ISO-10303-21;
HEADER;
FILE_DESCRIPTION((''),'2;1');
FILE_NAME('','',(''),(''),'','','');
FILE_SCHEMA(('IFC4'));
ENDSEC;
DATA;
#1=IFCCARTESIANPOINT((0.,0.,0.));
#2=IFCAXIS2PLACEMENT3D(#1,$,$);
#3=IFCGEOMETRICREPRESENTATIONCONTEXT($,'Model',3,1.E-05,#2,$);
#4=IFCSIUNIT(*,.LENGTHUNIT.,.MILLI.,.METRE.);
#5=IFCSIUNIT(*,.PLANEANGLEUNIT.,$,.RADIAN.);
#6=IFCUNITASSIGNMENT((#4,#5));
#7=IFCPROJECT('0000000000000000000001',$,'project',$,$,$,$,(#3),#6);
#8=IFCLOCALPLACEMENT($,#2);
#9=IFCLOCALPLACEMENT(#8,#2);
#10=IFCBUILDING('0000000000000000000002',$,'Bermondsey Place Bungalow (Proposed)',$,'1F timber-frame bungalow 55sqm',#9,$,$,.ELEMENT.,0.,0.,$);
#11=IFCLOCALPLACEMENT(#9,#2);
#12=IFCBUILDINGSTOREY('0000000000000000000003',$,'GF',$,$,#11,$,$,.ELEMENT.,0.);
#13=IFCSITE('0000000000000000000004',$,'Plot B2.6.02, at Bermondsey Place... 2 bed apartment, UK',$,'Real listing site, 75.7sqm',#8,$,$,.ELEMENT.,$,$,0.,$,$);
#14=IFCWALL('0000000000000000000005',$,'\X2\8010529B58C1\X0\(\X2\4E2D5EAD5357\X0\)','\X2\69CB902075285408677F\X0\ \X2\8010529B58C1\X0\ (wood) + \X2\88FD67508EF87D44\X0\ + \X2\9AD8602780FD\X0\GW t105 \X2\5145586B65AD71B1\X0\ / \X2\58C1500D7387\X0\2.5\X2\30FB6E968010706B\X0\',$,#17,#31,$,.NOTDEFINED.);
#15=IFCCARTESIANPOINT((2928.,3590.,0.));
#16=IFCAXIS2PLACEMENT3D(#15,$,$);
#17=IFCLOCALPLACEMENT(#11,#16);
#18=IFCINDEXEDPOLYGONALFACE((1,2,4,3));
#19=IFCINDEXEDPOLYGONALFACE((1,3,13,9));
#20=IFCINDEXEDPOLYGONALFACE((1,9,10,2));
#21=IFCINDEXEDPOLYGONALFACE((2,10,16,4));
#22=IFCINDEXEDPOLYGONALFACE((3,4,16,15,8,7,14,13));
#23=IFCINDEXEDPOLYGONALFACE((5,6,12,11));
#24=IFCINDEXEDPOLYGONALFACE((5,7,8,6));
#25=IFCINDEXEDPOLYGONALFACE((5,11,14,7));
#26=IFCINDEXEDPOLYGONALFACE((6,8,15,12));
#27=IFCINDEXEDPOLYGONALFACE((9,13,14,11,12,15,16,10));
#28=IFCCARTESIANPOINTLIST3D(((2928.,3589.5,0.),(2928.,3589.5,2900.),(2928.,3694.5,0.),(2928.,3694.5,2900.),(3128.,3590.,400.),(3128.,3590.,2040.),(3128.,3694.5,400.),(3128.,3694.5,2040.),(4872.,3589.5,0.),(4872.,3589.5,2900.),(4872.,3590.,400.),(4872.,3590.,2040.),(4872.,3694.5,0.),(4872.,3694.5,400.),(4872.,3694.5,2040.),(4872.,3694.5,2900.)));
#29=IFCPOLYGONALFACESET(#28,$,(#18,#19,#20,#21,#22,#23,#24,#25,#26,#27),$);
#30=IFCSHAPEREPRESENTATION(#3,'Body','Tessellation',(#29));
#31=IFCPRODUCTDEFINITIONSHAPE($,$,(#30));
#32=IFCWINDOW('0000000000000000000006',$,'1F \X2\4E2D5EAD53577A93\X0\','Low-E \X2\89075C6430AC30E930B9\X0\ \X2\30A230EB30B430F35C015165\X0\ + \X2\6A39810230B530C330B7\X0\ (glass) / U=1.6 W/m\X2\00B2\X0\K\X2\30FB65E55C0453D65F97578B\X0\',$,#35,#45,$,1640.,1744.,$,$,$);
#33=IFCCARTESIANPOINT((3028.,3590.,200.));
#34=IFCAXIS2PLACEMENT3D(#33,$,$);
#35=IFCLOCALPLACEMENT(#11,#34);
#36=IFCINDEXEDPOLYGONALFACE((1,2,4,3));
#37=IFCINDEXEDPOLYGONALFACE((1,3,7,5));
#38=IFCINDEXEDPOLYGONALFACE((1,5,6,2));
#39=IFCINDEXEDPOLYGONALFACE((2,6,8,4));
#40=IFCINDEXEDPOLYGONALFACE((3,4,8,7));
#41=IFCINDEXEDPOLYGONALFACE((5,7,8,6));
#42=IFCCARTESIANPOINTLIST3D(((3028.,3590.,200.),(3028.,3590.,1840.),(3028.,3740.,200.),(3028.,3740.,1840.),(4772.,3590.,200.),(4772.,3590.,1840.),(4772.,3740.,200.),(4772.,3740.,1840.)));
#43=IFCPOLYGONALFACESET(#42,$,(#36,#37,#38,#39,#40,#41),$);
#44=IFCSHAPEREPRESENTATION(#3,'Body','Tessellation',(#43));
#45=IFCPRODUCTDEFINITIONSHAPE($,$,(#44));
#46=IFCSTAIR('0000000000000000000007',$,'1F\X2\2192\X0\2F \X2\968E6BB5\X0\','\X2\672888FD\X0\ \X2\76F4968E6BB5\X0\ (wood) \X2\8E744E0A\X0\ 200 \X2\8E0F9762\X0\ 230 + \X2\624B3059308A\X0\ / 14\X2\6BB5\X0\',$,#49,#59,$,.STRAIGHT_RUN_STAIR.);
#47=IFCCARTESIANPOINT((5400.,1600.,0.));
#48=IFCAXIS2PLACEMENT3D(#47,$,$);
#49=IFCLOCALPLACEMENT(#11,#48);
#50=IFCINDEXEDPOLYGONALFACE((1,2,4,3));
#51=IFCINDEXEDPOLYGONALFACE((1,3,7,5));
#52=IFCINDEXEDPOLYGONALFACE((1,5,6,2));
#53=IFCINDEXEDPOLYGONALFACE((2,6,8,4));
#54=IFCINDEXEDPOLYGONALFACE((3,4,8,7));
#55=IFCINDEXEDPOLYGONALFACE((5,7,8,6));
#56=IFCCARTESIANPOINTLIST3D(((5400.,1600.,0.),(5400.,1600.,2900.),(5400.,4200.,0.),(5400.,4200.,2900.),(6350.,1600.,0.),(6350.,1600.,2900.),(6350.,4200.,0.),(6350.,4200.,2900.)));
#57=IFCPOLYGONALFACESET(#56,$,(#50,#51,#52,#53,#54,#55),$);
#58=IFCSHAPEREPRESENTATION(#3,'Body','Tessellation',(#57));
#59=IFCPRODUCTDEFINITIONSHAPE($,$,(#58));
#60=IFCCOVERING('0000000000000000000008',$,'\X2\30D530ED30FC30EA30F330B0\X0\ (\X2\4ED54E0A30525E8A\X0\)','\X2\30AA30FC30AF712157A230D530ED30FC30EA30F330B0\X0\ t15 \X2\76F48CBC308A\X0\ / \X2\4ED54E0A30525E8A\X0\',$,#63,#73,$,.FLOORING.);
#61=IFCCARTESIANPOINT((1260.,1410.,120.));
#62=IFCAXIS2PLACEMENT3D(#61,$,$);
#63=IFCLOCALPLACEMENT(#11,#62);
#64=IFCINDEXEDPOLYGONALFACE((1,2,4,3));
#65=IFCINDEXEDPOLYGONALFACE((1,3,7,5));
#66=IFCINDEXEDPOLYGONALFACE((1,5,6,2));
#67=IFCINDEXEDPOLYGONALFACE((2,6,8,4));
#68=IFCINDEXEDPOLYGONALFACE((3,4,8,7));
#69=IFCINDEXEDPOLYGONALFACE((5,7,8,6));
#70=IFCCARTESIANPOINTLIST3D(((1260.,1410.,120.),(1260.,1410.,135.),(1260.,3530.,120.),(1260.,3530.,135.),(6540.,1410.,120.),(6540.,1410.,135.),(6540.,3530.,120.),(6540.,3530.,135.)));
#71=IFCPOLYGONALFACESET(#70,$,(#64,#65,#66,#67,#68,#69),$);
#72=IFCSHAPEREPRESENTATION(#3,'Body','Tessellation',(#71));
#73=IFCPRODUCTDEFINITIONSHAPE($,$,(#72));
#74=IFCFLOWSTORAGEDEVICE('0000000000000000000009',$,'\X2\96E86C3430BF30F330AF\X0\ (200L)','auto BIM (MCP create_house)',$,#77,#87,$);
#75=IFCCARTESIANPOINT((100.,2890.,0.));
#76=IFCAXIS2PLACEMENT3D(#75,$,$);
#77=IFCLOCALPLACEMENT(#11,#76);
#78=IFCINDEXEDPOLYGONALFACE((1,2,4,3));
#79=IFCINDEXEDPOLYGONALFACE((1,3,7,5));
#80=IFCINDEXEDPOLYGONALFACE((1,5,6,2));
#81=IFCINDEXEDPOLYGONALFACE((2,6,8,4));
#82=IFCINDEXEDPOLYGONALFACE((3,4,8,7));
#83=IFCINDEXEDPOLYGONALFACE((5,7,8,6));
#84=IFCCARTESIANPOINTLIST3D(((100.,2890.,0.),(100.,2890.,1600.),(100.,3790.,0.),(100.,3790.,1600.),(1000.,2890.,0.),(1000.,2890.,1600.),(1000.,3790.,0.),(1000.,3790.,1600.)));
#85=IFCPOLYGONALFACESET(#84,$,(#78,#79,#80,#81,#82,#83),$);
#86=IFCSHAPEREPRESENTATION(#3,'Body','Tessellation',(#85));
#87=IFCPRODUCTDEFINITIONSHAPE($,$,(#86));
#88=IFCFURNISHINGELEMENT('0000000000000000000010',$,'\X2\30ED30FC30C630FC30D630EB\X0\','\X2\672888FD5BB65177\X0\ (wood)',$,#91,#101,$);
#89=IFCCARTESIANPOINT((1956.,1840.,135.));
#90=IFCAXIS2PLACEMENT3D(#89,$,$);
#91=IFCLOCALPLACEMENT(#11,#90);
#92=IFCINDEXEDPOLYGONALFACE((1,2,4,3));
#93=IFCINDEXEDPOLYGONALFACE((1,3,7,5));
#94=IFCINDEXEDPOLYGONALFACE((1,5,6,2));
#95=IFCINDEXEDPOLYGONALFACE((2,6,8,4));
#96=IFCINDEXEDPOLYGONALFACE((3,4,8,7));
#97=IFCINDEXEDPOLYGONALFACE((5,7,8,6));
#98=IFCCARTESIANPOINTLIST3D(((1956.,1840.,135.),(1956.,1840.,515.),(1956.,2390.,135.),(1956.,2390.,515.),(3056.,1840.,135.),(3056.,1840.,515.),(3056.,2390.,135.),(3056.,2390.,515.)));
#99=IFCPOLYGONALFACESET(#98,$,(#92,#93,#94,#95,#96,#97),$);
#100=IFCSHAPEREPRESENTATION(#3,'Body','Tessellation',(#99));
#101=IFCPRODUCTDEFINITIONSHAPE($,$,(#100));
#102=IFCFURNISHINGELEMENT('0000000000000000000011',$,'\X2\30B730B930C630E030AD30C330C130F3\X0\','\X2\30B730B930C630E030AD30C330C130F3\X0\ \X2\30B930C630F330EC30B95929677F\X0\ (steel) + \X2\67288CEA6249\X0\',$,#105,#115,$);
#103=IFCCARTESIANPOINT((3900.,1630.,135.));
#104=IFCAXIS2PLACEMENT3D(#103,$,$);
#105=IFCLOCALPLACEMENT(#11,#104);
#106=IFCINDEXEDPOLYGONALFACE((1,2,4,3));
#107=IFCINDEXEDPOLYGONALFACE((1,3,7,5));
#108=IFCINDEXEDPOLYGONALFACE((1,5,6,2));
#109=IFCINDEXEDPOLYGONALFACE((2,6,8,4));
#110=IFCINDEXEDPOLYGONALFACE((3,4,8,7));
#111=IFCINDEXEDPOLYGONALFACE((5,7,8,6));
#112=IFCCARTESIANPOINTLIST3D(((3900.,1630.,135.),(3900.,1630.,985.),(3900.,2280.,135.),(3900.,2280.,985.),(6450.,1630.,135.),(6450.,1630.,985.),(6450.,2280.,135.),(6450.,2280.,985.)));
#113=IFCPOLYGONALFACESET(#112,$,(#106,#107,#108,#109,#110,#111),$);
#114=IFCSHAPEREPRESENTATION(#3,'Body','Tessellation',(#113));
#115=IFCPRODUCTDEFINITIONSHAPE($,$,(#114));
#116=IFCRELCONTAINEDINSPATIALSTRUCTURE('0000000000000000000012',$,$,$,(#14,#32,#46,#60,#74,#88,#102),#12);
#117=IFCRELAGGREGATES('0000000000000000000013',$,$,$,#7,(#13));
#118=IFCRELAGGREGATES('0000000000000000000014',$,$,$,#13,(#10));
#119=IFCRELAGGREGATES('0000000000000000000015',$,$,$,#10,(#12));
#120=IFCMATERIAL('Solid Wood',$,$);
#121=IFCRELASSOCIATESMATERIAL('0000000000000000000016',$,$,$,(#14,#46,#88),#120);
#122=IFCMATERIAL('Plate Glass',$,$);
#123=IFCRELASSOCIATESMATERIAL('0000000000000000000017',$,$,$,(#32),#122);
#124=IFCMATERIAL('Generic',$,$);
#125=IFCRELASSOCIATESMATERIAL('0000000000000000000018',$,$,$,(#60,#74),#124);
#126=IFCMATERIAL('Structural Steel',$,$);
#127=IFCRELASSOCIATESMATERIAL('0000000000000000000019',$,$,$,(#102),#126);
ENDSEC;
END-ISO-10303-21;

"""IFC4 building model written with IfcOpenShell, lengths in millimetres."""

from ifc_helpers import new_model, si_unit, frame, frame_2d, origin, place, context, project, spatial, rectangle, extrude, material, element, fill, save


model = new_model("IFC4")

# Units and contexts
model_context = context("Model", 3, precision=1e-05, world=origin())
ifc_project = project(units=[si_unit("LENGTHUNIT", "METRE", prefix="MILLI"), si_unit("PLANEANGLEUNIT", "RADIAN")], contexts=[model_context])

# Site, building, storey
site_placement = place(None, origin())
site = spatial("IfcSite", under=ifc_project, at=site_placement, Name="Plot B2.6.02, at Bermondsey Place... 2 bed apartment, UK", ObjectType="Real listing site, 75.7sqm", CompositionType="ELEMENT", RefElevation=0.0)
building_placement = place(site_placement, origin())
building = spatial("IfcBuilding", under=site, at=building_placement, Name="Bermondsey Place Bungalow (Proposed)", ObjectType="1F timber-frame bungalow 55sqm", CompositionType="ELEMENT", ElevationOfRefHeight=0.0, ElevationOfTerrain=0.0)
storey_placement = place(building_placement, origin())
storey = spatial("IfcBuildingStorey", under=building, at=storey_placement, Name="GF", CompositionType="ELEMENT", Elevation=0.0)

# Shared definitions
ifc_material_1 = material(Name="Solid Wood")

# Shared definitions
ifc_material_2 = material(Name="Plate Glass")

# Wall, opening, window
wall_1_placement = place(storey_placement, frame((2928.0, 3590.0, 0.0)))
wall_1 = element("IfcWall", 1, at=wall_1_placement, inside=storey, material=ifc_material_1, Name="耐力壁(中庭南)", Description="構造用合板 耐力壁 (wood) + 製材軸組 + 高性能GW t105 充填断熱 / 壁倍率2.5・準耐火", PredefinedType="NOTDEFINED", context=model_context, shape_type="SweptSolid", body=[
    extrude(rectangle(XDim=1944.0, YDim=105.0, at=frame_2d((972.0, 52.0))), frame((2928.0, 3590.0, 0.0)), (0.0, 0.0, 1.0), 2900.0),
])
opening_1_placement = place(storey_placement, frame((3028.0, 3590.0, 200.0)))
opening_1 = element("IfcOpeningElement", 2, at=opening_1_placement, cuts=wall_1, PredefinedType="NOTDEFINED", context=model_context, shape_type="SweptSolid", body=[
    extrude(rectangle(XDim=1744.0, YDim=150.0, at=frame_2d((872.0, 75.0))), frame((3028.0, 3590.0, 200.0)), (0.0, 0.0, 1.0), 1640.0),
])
window_1_placement = place(storey_placement, frame((3028.0, 3590.0, 200.0)))
window_1 = element("IfcWindow", 3, at=window_1_placement, inside=storey, material=ifc_material_2, Name="1F 中庭南窓", Description="Low-E 複層ガラス アルゴン封入 + 樹脂サッシ (glass) / U=1.6 W/m²K・日射取得型", OverallHeight=1640.0, OverallWidth=1744.0, context=model_context, shape_type="SweptSolid", body=[
    extrude(rectangle(XDim=1744.0, YDim=150.0, at=frame_2d((872.0, 75.0))), frame((3028.0, 3590.0, 200.0)), (0.0, 0.0, 1.0), 1640.0),
])
fill(opening_1, window_1)

# Stair
stair_placement = place(storey_placement, frame((5400.0, 1600.0, 0.0)))
element("IfcStair", 4, at=stair_placement, inside=storey, material=ifc_material_1, Name="1F→2F 階段", Description="木製 直階段 (wood) 蹴上 200 踏面 230 + 手すり / 14段", PredefinedType="STRAIGHT_RUN_STAIR", context=model_context, shape_type="SweptSolid", body=[
    extrude(rectangle(XDim=950.0, YDim=2600.0, at=frame_2d((475.0, 1300.0))), frame((5400.0, 1600.0, 0.0)), (0.0, 0.0, 1.0), 2900.0),
])

# Covering
ifc_material_3 = material(Name="Generic")
covering_placement = place(storey_placement, frame((1260.0, 1410.0, 120.0)))
element("IfcCovering", 5, at=covering_placement, inside=storey, material=ifc_material_3, Name="フローリング (仕上げ床)", Description="オーク無垢フローリング t15 直貼り / 仕上げ床", PredefinedType="FLOORING", context=model_context, shape_type="SweptSolid", body=[
    extrude(rectangle(XDim=5280.0, YDim=2120.0, at=frame_2d((2640.0, 1060.0))), frame((1260.0, 1410.0, 120.0)), (0.0, 0.0, 1.0), 15.0),
])

# Flow storage device
flow_storage_device_placement = place(storey_placement, frame((100.0, 2890.0, 0.0)))
element("IfcFlowStorageDevice", 6, at=flow_storage_device_placement, inside=storey, material=ifc_material_3, Name="雨水タンク (200L)", Description="auto BIM (MCP create_house)", context=model_context, shape_type="SweptSolid", body=[
    extrude(rectangle(XDim=900.0, YDim=900.0, at=frame_2d((450.0, 450.0))), frame((100.0, 2890.0, 0.0)), (0.0, 0.0, 1.0), 1600.0),
])

# Furnishing elements
furnishing_1_placement = place(storey_placement, frame((1956.0, 1840.0, 135.0)))
element("IfcFurnishingElement", 7, at=furnishing_1_placement, inside=storey, material=ifc_material_1, Name="ローテーブル", Description="木製家具 (wood)", context=model_context, shape_type="SweptSolid", body=[
    extrude(rectangle(XDim=1100.0, YDim=550.0, at=frame_2d((550.0, 275.0))), frame((1956.0, 1840.0, 135.0)), (0.0, 0.0, 1.0), 380.0),
])
ifc_material_4 = material(Name="Structural Steel")
furnishing_2_placement = place(storey_placement, frame((3900.0, 1630.0, 135.0)))
element("IfcFurnishingElement", 8, at=furnishing_2_placement, inside=storey, material=ifc_material_4, Name="システムキッチン", Description="システムキッチン ステンレス天板 (steel) + 木質扉", context=model_context, shape_type="SweptSolid", body=[
    extrude(rectangle(XDim=2550.0, YDim=650.0, at=frame_2d((1275.0, 325.0))), frame((3900.0, 1630.0, 135.0)), (0.0, 0.0, 1.0), 850.0),
])

save(model, "model.ifc")
